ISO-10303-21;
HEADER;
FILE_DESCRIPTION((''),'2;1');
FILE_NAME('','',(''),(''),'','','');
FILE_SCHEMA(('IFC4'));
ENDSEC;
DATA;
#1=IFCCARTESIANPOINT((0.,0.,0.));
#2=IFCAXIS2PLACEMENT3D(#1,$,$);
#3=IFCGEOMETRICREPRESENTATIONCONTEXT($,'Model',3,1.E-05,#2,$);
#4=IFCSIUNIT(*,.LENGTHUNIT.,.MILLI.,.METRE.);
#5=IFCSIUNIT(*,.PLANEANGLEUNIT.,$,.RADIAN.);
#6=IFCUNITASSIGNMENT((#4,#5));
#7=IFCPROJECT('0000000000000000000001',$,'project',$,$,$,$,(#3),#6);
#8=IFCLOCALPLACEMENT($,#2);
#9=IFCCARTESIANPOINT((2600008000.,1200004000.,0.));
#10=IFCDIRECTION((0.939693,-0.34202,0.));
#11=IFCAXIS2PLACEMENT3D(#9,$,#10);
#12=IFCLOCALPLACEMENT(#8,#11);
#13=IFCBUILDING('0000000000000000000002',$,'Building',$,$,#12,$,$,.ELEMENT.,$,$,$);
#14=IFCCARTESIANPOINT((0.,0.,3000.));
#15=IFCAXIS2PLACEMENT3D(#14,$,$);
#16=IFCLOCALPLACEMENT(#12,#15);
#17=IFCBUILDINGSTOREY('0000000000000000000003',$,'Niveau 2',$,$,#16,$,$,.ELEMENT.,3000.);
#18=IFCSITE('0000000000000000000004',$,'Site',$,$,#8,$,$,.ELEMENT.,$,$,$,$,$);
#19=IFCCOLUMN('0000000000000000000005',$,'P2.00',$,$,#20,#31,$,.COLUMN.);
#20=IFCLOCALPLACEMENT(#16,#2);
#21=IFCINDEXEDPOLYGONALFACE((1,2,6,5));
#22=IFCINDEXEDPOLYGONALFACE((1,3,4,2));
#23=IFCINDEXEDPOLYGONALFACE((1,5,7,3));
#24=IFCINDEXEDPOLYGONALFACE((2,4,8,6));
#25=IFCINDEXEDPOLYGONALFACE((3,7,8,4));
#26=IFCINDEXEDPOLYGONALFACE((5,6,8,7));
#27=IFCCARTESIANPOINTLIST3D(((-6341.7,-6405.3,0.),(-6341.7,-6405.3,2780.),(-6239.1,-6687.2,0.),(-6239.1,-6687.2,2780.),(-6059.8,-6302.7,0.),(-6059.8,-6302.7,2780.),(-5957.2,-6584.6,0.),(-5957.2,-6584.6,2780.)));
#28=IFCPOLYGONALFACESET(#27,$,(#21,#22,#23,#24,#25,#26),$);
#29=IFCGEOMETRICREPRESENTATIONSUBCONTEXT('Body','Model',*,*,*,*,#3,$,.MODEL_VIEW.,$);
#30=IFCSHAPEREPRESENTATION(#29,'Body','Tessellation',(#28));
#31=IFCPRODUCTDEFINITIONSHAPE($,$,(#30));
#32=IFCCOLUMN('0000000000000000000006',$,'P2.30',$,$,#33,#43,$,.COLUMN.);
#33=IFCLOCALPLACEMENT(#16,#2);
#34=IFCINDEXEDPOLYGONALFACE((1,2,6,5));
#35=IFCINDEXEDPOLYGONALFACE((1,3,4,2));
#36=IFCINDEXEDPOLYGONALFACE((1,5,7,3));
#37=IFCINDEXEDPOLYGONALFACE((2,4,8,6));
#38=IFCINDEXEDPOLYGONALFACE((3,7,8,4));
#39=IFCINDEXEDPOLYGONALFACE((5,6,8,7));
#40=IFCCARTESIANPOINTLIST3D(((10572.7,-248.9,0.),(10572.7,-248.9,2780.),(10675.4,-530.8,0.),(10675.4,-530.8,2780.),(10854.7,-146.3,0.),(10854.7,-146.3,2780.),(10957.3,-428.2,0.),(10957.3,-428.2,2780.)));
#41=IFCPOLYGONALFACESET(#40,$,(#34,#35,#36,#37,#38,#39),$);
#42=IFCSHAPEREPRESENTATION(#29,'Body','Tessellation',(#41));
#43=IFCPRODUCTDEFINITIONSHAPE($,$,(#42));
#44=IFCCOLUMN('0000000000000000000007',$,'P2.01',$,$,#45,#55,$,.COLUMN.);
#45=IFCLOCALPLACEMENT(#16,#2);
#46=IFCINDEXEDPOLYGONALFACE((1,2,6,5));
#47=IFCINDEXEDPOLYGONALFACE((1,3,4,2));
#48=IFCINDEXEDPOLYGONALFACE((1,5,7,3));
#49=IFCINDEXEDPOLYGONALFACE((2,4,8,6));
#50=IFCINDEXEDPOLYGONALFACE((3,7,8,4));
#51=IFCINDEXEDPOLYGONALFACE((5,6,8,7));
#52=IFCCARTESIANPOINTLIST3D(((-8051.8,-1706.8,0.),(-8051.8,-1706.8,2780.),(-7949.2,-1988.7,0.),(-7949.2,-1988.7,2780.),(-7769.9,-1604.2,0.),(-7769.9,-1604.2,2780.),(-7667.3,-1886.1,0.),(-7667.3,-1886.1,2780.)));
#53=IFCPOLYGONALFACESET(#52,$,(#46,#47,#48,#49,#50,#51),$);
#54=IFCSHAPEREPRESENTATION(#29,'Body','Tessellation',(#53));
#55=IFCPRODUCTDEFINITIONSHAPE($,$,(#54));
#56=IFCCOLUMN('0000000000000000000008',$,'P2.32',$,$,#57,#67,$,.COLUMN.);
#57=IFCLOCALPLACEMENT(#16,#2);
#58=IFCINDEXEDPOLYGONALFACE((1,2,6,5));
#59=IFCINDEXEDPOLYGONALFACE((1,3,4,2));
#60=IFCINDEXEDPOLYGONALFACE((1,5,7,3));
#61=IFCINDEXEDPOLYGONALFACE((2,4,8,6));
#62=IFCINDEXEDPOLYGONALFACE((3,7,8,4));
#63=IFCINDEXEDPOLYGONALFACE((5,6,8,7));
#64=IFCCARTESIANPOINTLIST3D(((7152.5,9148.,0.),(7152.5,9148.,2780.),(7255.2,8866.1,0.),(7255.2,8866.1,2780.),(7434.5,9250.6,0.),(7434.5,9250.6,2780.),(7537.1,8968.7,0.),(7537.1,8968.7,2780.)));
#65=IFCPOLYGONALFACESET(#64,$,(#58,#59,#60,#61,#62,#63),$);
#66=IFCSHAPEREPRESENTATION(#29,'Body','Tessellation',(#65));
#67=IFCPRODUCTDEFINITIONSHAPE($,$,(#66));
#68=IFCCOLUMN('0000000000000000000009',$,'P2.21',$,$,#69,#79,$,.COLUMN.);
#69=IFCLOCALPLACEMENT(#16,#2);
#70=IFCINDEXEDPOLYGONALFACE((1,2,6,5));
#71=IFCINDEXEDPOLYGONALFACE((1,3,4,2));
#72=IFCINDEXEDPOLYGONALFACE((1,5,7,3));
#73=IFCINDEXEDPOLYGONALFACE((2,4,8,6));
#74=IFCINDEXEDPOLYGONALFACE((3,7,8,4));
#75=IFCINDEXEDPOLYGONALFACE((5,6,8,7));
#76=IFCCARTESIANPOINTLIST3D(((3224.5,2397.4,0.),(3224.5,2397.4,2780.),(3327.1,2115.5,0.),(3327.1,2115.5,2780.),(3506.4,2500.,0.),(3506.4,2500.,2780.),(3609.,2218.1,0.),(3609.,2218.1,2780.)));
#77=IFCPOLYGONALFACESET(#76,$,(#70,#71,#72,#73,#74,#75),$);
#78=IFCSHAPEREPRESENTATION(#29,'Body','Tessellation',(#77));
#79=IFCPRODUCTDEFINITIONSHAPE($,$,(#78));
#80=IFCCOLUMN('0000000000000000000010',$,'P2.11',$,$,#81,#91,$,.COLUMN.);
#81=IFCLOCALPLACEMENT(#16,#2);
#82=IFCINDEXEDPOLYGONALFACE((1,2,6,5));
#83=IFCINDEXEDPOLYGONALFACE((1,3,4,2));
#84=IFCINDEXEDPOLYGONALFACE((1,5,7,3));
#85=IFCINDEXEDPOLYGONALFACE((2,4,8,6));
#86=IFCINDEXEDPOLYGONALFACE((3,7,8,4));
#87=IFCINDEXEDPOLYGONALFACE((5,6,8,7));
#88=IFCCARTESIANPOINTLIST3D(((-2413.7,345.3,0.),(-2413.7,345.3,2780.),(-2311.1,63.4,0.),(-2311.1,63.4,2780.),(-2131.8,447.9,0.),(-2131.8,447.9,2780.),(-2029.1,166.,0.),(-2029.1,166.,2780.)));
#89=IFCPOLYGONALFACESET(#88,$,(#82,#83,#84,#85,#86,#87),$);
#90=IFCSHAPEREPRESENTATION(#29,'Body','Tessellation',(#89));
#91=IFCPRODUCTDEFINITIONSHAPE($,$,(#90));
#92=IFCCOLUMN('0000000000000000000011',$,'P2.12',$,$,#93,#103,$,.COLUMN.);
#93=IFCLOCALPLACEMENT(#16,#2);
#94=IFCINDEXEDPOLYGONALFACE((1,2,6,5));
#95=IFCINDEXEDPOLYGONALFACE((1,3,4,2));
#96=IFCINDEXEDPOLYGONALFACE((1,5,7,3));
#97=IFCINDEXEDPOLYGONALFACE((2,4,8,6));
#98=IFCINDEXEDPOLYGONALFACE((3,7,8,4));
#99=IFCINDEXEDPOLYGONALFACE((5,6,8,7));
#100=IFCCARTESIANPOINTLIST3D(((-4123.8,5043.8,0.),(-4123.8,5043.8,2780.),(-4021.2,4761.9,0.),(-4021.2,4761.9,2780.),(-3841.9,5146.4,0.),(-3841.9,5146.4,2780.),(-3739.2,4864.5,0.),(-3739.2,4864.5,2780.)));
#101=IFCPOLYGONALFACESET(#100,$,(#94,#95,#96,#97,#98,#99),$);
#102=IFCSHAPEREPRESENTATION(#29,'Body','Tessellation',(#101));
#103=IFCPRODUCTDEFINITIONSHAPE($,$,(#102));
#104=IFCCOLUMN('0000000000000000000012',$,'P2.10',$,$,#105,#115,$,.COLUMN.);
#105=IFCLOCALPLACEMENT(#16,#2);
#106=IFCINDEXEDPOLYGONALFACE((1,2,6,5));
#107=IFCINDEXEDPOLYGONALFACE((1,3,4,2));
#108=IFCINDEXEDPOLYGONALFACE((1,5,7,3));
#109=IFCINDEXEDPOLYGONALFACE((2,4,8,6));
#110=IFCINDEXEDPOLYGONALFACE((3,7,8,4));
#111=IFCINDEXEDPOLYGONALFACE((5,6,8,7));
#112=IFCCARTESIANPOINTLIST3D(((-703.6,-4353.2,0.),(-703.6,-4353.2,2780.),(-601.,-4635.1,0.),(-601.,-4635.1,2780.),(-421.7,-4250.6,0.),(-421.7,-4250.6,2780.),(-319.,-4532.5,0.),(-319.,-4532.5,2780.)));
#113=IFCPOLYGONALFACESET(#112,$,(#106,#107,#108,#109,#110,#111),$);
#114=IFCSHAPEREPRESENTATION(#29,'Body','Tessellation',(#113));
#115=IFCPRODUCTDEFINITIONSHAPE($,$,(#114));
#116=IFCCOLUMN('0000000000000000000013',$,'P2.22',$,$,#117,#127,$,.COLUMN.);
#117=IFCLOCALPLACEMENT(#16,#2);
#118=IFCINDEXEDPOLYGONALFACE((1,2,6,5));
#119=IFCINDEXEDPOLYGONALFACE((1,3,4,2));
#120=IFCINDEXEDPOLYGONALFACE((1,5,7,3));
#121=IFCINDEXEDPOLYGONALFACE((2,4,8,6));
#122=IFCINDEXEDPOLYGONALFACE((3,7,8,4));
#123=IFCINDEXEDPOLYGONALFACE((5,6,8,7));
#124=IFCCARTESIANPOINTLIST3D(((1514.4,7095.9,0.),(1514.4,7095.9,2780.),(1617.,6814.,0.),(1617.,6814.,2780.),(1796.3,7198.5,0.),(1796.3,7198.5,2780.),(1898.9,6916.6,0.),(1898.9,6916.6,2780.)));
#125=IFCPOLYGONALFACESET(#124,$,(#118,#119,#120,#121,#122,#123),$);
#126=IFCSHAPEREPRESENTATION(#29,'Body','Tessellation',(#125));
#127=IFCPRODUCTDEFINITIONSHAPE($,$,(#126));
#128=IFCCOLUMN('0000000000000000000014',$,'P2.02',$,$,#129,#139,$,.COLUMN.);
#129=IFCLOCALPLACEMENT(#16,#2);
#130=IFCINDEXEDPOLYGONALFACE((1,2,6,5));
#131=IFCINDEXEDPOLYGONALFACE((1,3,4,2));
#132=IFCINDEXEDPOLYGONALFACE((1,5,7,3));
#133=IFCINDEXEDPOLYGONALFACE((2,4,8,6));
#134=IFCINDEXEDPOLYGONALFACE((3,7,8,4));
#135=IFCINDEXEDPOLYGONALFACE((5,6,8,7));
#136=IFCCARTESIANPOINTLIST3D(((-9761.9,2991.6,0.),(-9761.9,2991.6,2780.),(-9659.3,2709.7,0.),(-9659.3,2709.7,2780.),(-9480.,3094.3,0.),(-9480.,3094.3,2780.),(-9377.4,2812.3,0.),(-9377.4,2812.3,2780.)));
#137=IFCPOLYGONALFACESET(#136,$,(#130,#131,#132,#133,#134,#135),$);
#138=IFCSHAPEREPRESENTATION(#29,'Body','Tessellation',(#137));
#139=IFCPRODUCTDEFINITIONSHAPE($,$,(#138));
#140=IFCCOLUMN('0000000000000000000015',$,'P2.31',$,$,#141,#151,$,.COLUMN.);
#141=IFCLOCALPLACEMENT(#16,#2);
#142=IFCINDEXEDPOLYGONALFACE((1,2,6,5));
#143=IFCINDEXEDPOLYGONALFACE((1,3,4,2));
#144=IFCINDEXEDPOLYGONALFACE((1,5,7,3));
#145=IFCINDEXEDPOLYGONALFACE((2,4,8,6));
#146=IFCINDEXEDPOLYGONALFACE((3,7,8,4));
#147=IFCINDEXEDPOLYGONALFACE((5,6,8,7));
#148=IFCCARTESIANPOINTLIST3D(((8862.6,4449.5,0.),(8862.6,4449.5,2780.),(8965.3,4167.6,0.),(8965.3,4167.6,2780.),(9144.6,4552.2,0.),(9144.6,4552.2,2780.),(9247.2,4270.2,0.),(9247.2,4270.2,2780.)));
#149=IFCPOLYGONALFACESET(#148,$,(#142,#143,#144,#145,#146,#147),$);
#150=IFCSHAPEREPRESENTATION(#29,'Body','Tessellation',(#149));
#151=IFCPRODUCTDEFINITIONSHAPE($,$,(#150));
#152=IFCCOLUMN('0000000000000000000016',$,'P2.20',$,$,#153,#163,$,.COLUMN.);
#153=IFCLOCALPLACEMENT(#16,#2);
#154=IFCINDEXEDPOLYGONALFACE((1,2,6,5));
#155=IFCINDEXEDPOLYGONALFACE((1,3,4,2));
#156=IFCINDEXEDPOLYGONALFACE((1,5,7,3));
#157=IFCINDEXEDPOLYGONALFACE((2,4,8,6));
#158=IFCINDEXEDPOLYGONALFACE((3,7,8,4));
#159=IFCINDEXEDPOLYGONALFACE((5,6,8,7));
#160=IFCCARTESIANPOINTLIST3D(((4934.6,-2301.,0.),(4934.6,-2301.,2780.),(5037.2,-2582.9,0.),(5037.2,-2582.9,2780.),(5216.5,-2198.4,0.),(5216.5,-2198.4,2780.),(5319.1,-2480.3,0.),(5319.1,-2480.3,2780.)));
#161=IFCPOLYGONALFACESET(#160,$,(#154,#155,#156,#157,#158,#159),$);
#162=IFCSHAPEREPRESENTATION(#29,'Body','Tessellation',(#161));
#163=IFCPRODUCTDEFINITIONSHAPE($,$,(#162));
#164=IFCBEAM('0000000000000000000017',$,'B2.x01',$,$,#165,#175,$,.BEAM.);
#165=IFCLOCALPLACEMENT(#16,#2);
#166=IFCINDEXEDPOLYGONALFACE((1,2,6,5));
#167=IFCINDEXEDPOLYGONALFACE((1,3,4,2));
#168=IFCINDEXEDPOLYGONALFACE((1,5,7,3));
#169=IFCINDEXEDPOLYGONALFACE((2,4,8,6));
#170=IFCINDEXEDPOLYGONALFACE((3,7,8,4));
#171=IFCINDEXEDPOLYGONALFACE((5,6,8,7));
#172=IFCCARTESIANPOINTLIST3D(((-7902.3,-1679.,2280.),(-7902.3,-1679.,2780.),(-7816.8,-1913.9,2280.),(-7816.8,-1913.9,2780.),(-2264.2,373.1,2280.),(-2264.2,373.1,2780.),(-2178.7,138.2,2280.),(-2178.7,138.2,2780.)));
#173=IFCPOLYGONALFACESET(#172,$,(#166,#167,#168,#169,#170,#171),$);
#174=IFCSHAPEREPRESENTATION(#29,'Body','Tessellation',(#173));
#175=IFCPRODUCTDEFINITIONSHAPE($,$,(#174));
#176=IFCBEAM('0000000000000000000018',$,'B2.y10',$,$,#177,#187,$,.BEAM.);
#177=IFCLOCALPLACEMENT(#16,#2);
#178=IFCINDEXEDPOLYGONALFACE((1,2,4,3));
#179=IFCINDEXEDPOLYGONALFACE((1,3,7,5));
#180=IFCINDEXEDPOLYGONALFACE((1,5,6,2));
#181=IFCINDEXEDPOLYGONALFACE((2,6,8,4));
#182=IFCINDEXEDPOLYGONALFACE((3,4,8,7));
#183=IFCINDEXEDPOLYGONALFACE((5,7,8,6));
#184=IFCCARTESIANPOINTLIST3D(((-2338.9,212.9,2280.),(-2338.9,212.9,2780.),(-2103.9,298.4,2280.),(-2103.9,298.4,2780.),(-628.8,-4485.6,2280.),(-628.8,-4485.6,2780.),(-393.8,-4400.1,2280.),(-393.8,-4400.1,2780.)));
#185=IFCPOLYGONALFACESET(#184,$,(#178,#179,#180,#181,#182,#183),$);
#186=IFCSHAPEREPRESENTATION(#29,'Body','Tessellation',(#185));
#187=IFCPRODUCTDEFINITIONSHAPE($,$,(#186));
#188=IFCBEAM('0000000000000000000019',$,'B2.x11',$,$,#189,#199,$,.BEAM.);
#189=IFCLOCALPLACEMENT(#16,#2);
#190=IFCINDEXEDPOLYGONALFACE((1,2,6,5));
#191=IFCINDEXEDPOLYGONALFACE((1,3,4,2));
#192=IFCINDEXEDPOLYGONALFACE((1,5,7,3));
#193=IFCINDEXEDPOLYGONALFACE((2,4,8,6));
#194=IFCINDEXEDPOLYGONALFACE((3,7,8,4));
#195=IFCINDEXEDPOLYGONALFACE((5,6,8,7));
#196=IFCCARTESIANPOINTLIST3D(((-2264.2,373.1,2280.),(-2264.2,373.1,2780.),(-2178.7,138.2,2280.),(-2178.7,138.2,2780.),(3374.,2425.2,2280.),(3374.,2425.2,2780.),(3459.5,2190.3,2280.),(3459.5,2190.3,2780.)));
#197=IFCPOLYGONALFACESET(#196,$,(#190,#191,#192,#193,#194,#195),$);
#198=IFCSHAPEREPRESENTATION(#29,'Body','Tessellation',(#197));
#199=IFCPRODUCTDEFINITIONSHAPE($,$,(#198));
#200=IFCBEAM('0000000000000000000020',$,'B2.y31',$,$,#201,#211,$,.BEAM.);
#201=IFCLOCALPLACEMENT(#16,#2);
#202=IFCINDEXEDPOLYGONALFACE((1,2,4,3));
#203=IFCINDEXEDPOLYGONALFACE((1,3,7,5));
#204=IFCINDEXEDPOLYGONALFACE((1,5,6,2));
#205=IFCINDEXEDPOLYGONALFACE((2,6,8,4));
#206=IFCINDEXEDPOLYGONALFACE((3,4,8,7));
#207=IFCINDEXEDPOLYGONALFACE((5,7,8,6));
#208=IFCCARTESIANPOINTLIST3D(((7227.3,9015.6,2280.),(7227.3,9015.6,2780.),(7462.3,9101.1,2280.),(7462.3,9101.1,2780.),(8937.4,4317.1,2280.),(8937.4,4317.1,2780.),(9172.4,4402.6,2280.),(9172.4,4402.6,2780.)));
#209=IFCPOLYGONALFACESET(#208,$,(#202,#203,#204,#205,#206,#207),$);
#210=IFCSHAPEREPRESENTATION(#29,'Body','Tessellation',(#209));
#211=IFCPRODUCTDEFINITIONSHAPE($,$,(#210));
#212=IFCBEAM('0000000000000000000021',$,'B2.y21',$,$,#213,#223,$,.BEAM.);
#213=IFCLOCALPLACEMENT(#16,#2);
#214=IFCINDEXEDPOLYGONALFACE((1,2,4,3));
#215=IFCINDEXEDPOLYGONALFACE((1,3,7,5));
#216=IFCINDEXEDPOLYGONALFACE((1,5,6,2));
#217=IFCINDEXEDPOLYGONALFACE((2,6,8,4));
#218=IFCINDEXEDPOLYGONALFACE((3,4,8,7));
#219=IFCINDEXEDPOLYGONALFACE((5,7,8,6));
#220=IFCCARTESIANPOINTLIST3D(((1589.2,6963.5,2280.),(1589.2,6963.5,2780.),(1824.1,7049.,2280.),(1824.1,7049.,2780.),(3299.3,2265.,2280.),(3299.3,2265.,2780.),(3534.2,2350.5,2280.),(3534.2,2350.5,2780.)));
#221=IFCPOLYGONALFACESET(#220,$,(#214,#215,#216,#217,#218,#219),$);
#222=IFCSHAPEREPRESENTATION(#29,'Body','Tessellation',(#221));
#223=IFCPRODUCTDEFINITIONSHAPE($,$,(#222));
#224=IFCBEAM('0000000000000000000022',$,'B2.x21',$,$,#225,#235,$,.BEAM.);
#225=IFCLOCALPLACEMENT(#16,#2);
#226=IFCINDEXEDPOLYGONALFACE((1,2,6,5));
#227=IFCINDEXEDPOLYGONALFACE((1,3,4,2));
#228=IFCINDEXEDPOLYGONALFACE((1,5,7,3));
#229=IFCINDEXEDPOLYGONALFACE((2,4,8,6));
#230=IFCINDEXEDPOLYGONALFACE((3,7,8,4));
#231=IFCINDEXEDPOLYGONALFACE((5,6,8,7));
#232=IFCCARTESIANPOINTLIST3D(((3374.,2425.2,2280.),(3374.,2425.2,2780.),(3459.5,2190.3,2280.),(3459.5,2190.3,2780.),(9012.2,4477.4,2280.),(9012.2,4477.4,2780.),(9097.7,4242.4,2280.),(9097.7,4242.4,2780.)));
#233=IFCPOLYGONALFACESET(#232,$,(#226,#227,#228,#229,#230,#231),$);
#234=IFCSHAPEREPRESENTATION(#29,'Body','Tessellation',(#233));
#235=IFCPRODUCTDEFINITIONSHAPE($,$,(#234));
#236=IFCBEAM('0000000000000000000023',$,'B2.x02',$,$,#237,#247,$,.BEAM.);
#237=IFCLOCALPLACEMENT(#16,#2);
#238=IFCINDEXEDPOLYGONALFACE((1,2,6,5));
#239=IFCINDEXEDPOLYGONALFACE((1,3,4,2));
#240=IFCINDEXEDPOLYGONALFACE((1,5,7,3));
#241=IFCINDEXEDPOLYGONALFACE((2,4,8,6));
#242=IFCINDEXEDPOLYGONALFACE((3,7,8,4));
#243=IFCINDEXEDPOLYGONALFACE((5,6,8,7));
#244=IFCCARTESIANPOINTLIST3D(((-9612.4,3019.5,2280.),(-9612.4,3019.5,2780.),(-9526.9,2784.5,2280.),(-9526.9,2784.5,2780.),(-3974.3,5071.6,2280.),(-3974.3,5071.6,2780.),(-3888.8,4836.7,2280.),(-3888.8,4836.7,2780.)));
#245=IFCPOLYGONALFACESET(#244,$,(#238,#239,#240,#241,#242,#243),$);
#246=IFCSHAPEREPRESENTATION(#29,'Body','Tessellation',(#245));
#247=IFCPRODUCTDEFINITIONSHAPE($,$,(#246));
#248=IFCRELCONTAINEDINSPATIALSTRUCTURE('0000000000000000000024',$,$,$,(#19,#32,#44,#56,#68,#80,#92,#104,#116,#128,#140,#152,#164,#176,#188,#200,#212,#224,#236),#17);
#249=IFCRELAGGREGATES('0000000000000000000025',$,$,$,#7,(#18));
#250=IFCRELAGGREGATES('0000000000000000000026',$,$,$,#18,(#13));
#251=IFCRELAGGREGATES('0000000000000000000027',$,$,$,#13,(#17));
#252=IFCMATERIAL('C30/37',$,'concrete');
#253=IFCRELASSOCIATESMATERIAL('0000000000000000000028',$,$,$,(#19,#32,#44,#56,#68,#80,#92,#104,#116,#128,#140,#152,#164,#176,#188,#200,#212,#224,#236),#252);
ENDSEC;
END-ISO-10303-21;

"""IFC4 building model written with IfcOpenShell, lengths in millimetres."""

from ifc_helpers import new_model, si_unit, frame, origin, place, context, subcontext, project, spatial, rectangle, extrude, material, element, save


model = new_model("IFC4")

# Units and contexts
model_context = context("Model", 3, precision=1e-05, world=origin())
body_context = subcontext(model_context, "Body", "Model", "MODEL_VIEW")
ifc_project = project(units=[si_unit("LENGTHUNIT", "METRE", prefix="MILLI"), si_unit("PLANEANGLEUNIT", "RADIAN")], contexts=[model_context])

# Site, building, storey
site_placement = place(None, origin())
site = spatial("IfcSite", under=ifc_project, at=site_placement, Name="Site", CompositionType="ELEMENT")
building_placement = place(site_placement, frame((2600008000.0, 1200004000.0, 0.0), x_axis=(0.939693, -0.34202, 0.0)))
building = spatial("IfcBuilding", under=site, at=building_placement, Name="Building", CompositionType="ELEMENT")
storey_placement = place(building_placement, frame((0.0, 0.0, 3000.0)))
storey = spatial("IfcBuildingStorey", under=building, at=storey_placement, Name="Niveau 2", CompositionType="ELEMENT", Elevation=3000.0)

# Columns
ifc_material = material(Name="C30/37", Category="concrete")
for number, where, z_axis, x_axis, name in (
    (1, (-6149.5, -6494.9, 0.0), (0.0, 0.0, 1.0), (0.939693, 0.34202, 0.0), "P2.00"),
    (2, (10765.0, -338.6, 0.0), (0.0, 0.0, 1.0), (0.939693, 0.34202, 0.0), "P2.30"),
    (3, (-7859.6, -1796.5, 0.0), (0.0, 0.0, 1.0), (0.939693, 0.34202, 0.0), "P2.01"),
    (4, (7344.8, 9058.4, 0.0), (0.0, 0.0, 1.0), (0.939693, 0.34202, 0.0), "P2.32"),
    (5, (3416.8, 2307.8, 0.0), (0.0, 0.0, 1.0), (0.939693, 0.34202, 0.0), "P2.21"),
    (6, (-2221.4, 255.7, 0.0), (0.0, 0.0, 1.0), (0.939693, 0.34202, 0.0), "P2.11"),
    (7, (-3931.5, 4954.1, 0.0), (0.0, 0.0, 1.0), (0.939693, 0.34202, 0.0), "P2.12"),
    (8, (-511.3, -4442.8, 0.0), (0.0, 0.0, 1.0), (0.939693, 0.34202, 0.0), "P2.10"),
    (9, (1706.6, 7006.2, 0.0), (0.0, 0.0, 1.0), (0.939693, 0.34202, 0.0), "P2.22"),
    (10, (-9569.7, 2902.0, 0.0), (0.0, 0.0, 1.0), (0.939693, 0.34202, 0.0), "P2.02"),
    (11, (9054.9, 4359.9, 0.0), (0.0, 0.0, 1.0), (0.939693, 0.34202, 0.0), "P2.31"),
    (12, (5126.9, -2390.7, 0.0), (0.0, 0.0, 1.0), (0.939693, 0.34202, 0.0), "P2.20"),
):
    element("IfcColumn", number, at=place(storey_placement, frame(where, z_axis=z_axis, x_axis=x_axis)), inside=storey, material=ifc_material, Name=name, PredefinedType="COLUMN", context=body_context, shape_type="SweptSolid", body=[
        extrude(rectangle(XDim=300.0, YDim=300.0), origin(), (0.0, 0.0, 1.0), 2780.0),
    ])

# Beams
beam_1_placement = place(storey_placement, frame((-7859.6, -1796.5, 2530.0), z_axis=(0.939693, 0.34202, 0.0), x_axis=(-0.34202, 0.939693, 0.0)))
element("IfcBeam", 13, at=beam_1_placement, inside=storey, material=ifc_material, Name="B2.x01", PredefinedType="BEAM", context=body_context, shape_type="SweptSolid", body=[
    extrude(rectangle(XDim=250.0, YDim=500.0), origin(), (0.0, 0.0, 1.0), 6000.0),
])
beam_2_placement = place(storey_placement, frame((-511.3, -4442.8, 2530.0), z_axis=(-0.34202, 0.939693, 0.0), x_axis=(-0.939693, -0.34202, 0.0)))
element("IfcBeam", 14, at=beam_2_placement, inside=storey, material=ifc_material, Name="B2.y10", PredefinedType="BEAM", context=body_context, shape_type="SweptSolid", body=[
    extrude(rectangle(XDim=250.0, YDim=500.0), origin(), (0.0, 0.0, 1.0), 5000.0),
])
beam_3_placement = place(storey_placement, frame((-2221.4, 255.7, 2530.0), z_axis=(0.939693, 0.34202, 0.0), x_axis=(-0.34202, 0.939693, 0.0)))
element("IfcBeam", 15, at=beam_3_placement, inside=storey, material=ifc_material, Name="B2.x11", PredefinedType="BEAM", context=body_context, shape_type="SweptSolid", body=[
    extrude(rectangle(XDim=250.0, YDim=500.0), origin(), (0.0, 0.0, 1.0), 6000.0),
])
for number, where, z_axis, x_axis, name in (
    (16, (9054.9, 4359.9, 2530.0), (-0.34202, 0.939693, 0.0), (-0.939693, -0.34202, 0.0), "B2.y31"),
    (17, (3416.8, 2307.8, 2530.0), (-0.34202, 0.939693, 0.0), (-0.939693, -0.34202, 0.0), "B2.y21"),
):
    element("IfcBeam", number, at=place(storey_placement, frame(where, z_axis=z_axis, x_axis=x_axis)), inside=storey, material=ifc_material, Name=name, PredefinedType="BEAM", context=body_context, shape_type="SweptSolid", body=[
        extrude(rectangle(XDim=250.0, YDim=500.0), origin(), (0.0, 0.0, 1.0), 5000.0),
    ])
for number, where, z_axis, x_axis, name in (
    (18, (3416.8, 2307.8, 2530.0), (0.939693, 0.34202, 0.0), (-0.34202, 0.939693, 0.0), "B2.x21"),
    (19, (-9569.7, 2902.0, 2530.0), (0.939693, 0.34202, 0.0), (-0.34202, 0.939693, 0.0), "B2.x02"),
):
    element("IfcBeam", number, at=place(storey_placement, frame(where, z_axis=z_axis, x_axis=x_axis)), inside=storey, material=ifc_material, Name=name, PredefinedType="BEAM", context=body_context, shape_type="SweptSolid", body=[
        extrude(rectangle(XDim=250.0, YDim=500.0), origin(), (0.0, 0.0, 1.0), 6000.0),
    ])

save(model, "model.ifc")
